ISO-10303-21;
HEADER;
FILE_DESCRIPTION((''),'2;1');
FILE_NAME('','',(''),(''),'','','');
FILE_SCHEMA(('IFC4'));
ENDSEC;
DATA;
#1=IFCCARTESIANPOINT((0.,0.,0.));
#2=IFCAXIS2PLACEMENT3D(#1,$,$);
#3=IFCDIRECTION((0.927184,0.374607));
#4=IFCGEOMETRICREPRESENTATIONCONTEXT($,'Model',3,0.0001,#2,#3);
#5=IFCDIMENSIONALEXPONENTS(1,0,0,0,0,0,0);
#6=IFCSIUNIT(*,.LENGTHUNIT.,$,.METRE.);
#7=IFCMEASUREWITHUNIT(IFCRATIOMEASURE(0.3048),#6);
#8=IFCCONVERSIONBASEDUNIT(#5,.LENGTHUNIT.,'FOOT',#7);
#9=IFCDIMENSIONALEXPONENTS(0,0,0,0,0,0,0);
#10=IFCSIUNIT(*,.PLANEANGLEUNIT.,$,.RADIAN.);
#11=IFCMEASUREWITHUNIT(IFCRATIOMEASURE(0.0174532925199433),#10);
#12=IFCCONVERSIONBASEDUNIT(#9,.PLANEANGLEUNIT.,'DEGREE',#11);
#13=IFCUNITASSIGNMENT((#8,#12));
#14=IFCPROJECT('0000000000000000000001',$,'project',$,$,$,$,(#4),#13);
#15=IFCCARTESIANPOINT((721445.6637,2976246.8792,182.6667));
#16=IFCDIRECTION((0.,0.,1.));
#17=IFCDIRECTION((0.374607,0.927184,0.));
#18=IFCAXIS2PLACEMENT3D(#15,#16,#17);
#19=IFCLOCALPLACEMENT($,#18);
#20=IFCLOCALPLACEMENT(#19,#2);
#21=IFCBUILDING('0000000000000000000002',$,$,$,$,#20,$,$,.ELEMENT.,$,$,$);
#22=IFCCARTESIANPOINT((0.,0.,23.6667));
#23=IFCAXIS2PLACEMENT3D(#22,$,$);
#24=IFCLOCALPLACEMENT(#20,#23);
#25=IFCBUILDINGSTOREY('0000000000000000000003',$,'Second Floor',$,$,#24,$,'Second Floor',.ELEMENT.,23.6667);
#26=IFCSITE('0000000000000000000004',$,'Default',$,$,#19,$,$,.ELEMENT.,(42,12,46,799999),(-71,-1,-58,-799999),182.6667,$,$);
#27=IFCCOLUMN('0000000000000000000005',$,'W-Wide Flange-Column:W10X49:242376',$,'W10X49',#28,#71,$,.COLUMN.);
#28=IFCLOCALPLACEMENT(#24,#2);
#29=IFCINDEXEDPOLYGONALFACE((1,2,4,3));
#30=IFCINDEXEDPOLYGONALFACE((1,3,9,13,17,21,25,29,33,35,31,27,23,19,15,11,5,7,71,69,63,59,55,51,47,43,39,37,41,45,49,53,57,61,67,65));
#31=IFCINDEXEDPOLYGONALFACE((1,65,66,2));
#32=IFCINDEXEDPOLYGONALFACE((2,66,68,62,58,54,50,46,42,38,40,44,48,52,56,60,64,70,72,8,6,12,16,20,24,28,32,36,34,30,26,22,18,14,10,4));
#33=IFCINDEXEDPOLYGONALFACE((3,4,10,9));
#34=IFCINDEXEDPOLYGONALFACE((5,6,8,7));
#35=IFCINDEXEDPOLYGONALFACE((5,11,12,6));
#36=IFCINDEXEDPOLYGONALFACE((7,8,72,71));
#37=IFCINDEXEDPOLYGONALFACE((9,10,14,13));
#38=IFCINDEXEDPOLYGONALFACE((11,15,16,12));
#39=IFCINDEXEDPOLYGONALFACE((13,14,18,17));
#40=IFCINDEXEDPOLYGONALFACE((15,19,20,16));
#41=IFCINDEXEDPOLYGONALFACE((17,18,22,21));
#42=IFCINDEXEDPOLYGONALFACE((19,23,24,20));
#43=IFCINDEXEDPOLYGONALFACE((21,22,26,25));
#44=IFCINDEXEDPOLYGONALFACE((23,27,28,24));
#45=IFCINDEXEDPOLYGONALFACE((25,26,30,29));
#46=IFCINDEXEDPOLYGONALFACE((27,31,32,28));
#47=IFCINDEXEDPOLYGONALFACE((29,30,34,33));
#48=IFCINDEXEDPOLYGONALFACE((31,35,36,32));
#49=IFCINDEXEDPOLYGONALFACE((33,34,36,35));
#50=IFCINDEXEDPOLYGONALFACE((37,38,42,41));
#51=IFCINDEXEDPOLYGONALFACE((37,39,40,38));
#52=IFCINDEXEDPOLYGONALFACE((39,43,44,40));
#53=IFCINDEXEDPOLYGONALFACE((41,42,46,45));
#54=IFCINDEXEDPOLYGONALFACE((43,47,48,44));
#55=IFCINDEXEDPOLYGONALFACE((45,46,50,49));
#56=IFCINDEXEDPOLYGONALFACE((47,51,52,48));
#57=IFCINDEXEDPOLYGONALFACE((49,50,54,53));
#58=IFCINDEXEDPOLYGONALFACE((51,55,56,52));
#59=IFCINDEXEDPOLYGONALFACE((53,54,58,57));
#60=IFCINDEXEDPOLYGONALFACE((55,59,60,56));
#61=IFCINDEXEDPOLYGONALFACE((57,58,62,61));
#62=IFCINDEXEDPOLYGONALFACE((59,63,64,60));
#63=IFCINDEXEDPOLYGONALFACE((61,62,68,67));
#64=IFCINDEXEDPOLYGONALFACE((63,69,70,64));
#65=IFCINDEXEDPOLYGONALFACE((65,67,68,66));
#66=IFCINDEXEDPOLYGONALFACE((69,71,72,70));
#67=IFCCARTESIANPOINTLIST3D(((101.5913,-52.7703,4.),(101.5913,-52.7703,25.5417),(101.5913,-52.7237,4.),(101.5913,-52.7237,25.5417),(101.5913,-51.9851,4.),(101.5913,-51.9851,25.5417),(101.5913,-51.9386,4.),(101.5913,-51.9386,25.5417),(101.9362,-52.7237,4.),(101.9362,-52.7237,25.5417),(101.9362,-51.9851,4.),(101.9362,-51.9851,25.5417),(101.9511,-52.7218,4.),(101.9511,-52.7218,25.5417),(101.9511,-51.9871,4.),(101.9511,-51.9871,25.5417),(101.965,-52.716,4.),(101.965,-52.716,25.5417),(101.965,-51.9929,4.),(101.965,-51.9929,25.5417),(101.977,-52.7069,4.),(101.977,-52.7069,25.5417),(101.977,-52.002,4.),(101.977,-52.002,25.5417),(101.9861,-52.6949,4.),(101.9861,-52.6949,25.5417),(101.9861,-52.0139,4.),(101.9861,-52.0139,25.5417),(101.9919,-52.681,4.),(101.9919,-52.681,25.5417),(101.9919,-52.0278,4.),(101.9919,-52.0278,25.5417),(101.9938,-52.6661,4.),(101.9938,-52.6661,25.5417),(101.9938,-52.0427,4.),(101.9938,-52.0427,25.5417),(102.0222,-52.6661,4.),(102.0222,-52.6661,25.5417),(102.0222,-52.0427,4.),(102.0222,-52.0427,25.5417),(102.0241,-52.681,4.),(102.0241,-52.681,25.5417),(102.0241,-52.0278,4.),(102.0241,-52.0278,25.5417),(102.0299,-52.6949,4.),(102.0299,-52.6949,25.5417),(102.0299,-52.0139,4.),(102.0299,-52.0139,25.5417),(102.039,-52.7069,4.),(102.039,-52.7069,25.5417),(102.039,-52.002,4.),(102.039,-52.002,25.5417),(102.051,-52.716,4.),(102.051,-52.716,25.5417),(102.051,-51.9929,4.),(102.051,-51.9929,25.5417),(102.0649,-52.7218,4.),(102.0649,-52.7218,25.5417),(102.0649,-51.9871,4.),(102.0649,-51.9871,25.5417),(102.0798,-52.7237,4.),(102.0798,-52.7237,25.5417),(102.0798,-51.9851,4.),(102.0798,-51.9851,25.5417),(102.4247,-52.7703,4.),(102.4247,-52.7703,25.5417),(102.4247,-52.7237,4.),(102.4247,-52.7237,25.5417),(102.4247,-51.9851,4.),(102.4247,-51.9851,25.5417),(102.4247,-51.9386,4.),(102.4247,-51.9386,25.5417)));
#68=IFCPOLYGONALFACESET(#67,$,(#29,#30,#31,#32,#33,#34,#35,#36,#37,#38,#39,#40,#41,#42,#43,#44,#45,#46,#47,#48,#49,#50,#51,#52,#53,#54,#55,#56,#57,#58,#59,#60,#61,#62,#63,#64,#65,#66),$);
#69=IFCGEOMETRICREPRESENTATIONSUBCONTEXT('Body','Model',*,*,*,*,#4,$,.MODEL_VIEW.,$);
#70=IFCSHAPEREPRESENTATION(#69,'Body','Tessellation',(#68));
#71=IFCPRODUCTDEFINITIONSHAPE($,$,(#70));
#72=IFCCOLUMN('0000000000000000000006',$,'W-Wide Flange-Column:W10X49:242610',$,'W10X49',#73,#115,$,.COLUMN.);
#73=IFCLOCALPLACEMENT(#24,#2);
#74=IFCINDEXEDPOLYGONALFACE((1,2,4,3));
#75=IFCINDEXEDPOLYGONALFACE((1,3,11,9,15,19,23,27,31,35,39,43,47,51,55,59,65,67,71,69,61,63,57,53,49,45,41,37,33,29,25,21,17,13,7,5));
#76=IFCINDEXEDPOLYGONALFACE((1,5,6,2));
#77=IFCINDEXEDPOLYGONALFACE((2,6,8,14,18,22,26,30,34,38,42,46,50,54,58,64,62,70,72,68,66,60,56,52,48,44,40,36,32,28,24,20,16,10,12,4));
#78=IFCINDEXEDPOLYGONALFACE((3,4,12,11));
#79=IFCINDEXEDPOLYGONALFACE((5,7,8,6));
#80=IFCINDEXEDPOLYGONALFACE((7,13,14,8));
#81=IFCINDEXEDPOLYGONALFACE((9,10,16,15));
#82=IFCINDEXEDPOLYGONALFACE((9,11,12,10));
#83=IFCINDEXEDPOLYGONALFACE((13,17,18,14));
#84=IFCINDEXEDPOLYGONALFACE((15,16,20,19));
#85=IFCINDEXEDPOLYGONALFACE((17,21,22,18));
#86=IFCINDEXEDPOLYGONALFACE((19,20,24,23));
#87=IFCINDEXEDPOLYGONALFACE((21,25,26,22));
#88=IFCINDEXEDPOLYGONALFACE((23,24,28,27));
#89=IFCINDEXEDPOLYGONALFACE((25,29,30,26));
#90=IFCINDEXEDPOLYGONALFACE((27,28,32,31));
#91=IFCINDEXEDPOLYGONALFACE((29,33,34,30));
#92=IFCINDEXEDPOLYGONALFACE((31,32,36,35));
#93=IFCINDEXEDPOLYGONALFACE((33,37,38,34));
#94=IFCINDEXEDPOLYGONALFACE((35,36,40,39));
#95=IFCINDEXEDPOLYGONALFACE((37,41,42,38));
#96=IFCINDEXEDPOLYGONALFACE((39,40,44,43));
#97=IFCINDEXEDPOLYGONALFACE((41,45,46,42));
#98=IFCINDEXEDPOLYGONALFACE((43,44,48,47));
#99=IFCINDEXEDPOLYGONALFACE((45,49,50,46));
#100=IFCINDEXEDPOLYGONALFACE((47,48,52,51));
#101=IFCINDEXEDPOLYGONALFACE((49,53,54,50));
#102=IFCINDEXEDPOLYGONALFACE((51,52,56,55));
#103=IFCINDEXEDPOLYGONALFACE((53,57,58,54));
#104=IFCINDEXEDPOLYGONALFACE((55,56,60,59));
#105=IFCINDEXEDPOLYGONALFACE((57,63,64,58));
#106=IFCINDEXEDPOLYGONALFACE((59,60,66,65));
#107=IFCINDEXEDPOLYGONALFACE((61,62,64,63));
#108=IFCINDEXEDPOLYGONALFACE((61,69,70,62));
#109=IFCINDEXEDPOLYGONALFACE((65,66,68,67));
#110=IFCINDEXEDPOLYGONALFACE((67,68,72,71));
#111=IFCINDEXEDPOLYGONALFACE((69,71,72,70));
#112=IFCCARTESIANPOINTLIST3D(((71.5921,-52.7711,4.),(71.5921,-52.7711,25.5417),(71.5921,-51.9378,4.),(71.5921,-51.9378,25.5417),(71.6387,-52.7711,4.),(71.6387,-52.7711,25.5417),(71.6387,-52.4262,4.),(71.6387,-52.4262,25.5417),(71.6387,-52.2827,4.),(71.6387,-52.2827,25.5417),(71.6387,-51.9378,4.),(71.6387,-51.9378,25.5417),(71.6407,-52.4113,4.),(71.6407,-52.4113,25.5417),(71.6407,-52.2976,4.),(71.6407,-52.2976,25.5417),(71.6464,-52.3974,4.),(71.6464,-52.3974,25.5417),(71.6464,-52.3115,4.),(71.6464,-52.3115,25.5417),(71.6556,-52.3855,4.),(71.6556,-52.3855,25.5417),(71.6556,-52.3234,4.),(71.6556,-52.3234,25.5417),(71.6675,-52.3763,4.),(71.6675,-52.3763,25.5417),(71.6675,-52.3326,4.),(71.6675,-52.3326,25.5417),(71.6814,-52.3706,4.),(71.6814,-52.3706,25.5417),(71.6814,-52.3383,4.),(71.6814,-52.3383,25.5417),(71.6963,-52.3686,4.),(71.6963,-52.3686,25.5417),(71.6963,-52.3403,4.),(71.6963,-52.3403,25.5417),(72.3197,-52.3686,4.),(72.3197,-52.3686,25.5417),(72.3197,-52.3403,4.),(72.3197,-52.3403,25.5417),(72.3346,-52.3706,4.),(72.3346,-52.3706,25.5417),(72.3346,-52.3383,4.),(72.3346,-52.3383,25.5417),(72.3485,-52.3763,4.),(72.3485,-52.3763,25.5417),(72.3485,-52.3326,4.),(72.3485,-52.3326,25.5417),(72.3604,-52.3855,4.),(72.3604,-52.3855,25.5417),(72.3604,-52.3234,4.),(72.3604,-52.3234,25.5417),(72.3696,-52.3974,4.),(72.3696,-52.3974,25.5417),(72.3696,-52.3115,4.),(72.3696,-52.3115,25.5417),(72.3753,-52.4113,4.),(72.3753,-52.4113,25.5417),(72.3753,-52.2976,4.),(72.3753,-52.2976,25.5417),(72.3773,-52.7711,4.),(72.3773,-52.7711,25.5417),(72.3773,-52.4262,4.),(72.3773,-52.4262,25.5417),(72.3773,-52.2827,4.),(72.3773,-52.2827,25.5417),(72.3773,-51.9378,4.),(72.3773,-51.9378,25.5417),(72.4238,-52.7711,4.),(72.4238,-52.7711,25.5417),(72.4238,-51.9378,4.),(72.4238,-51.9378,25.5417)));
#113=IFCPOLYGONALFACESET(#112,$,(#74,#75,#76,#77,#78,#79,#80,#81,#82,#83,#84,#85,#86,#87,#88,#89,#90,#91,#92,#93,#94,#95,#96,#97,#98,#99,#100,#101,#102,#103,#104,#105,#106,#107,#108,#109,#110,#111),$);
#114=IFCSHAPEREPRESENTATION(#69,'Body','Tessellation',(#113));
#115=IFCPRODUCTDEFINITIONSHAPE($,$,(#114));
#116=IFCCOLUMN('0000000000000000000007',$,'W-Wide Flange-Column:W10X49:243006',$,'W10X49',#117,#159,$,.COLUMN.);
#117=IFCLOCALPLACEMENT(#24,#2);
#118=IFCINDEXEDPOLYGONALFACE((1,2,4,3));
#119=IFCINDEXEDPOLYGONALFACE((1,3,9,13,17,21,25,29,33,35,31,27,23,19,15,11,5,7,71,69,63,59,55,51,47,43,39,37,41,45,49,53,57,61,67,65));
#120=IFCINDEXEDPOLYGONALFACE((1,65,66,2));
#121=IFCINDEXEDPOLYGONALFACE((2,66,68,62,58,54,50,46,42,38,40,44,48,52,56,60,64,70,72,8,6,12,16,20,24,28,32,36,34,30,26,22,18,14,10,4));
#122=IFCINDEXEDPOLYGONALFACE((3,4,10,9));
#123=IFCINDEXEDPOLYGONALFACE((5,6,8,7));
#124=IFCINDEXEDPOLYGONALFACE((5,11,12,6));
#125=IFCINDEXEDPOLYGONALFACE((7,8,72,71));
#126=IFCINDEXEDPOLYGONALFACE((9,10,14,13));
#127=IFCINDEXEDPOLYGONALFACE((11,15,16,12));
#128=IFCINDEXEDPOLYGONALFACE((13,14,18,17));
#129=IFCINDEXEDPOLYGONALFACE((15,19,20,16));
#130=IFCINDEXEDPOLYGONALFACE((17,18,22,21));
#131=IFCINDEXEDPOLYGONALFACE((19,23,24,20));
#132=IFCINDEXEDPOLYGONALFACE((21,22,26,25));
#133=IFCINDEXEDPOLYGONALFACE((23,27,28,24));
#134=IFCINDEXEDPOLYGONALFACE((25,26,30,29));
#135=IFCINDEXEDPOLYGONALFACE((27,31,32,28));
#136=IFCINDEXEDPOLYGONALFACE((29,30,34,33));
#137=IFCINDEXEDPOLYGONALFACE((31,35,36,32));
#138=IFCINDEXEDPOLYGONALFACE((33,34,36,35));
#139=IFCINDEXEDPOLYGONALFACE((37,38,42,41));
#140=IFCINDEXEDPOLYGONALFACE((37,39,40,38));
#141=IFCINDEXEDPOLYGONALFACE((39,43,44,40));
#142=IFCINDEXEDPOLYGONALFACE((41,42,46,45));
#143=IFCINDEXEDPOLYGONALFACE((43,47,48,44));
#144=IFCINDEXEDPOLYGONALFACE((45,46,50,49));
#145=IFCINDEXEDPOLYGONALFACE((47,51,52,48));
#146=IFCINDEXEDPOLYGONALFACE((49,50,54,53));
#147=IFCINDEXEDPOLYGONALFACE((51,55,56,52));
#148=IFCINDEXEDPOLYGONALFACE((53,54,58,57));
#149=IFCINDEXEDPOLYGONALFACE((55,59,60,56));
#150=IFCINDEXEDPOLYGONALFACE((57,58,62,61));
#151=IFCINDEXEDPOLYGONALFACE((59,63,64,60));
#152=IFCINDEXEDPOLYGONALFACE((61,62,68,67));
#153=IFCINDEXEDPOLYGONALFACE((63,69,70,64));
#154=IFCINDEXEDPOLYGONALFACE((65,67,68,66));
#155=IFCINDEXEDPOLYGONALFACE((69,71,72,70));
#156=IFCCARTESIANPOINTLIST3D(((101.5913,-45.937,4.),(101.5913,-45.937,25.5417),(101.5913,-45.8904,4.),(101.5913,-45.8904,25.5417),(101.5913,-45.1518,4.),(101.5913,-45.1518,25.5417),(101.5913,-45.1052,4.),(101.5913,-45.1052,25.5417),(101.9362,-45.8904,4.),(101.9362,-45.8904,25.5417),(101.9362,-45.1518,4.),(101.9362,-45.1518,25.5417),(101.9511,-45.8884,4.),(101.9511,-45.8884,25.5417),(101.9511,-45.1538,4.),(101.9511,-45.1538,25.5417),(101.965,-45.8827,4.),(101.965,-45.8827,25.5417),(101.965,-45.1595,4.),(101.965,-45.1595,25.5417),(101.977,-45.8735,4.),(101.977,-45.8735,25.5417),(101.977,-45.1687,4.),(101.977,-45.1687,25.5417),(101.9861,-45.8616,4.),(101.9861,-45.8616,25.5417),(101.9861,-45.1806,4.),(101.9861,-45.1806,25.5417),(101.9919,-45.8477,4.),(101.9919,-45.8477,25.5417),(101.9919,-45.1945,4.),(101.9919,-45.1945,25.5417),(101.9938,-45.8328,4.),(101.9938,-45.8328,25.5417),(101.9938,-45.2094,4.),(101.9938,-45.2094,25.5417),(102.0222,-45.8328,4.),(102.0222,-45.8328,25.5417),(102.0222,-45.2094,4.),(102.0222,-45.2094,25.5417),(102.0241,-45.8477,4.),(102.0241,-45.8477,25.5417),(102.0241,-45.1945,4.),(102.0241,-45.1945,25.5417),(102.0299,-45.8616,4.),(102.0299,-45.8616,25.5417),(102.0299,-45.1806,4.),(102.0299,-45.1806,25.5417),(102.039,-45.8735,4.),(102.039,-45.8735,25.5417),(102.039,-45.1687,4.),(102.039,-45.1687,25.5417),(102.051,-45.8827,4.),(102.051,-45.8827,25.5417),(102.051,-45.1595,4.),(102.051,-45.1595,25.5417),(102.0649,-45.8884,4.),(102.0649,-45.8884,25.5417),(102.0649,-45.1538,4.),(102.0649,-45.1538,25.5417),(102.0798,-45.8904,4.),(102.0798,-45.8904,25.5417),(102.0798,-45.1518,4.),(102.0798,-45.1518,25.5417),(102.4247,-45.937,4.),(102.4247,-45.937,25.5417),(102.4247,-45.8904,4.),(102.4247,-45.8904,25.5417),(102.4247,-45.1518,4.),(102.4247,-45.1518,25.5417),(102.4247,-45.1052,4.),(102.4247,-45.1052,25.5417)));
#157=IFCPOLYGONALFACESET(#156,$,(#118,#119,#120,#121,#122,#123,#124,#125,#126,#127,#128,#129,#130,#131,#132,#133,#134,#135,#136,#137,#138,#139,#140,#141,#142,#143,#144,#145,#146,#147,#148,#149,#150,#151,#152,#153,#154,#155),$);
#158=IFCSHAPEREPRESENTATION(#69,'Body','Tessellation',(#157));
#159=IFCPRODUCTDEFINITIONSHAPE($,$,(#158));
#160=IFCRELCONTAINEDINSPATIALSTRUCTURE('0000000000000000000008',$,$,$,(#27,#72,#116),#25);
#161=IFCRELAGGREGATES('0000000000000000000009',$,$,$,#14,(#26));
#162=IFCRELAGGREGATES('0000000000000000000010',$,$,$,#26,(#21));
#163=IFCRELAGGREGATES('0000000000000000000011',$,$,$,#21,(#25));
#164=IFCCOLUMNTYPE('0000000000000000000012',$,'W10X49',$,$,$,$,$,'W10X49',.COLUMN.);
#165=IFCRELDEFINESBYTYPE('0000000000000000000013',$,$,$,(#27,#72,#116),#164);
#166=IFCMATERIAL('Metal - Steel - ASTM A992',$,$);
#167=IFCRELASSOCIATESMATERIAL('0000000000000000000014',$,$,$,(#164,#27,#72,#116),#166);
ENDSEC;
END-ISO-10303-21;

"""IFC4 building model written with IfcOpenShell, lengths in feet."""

from ifc_helpers import new_model, entity, si_unit, converted_unit, direction, frame, frame_2d, origin, place, context, subcontext, project, spatial, i_section, extrude, source, transform, mapped, material, type_object, type_shapes, element, save


model = new_model("IFC4")

# Units and contexts
model_context = context("Model", 3, precision=0.0001, world=origin(), true_north=direction((0.927184, 0.374607)))
body_context = subcontext(model_context, "Body", "Model", "MODEL_VIEW")
ifc_project = project(units=[converted_unit("LENGTHUNIT", "FOOT", entity("IfcRatioMeasure", 0.3048), si_unit("LENGTHUNIT", "METRE"), dimensions=[1, 0, 0, 0, 0, 0, 0]), converted_unit("PLANEANGLEUNIT", "DEGREE", entity("IfcRatioMeasure", 0.0174532925199433), si_unit("PLANEANGLEUNIT", "RADIAN"), dimensions=[0, 0, 0, 0, 0, 0, 0])], contexts=[model_context])

# Site, building, storey
site_placement = place(None, frame((721445.6637, 2976246.8792, 182.6667), z_axis=(0.0, 0.0, 1.0), x_axis=(0.374607, 0.927184, 0.0)))
site = spatial("IfcSite", under=ifc_project, at=site_placement, Name="Default", CompositionType="ELEMENT", RefLatitude=(42, 12, 46, 799999), RefLongitude=(-71, -1, -58, -799999), RefElevation=182.6667)
building_placement = place(site_placement, origin())
building = spatial("IfcBuilding", under=site, at=building_placement, CompositionType="ELEMENT")
storey_placement = place(building_placement, frame((0.0, 0.0, 23.6667)))
storey = spatial("IfcBuildingStorey", under=building, at=storey_placement, Name="Second Floor", LongName="Second Floor", CompositionType="ELEMENT", Elevation=23.6667)

# Columns
ifc_material_1 = material(Name="Metal - Steel - ASTM A992")
column_type = type_object("IfcColumnType", Name="W10X49", ElementType="W10X49", PredefinedType="COLUMN", material=ifc_material_1)
shared_shape_1 = source(origin(), body_context, "Body", "SweptSolid", [
    extrude(i_section(OverallWidth=0.8333, OverallDepth=0.8317, WebThickness=0.0283, FlangeThickness=0.0465, FilletRadius=0.0576, at=frame_2d((0.0, 0.0), x_axis=(0.0, 1.0))), frame((0.0, 0.0, 27.6667), z_axis=(0.0, 0.0, 1.0), x_axis=(0.0, -1.0, 0.0)), (0.0, 0.0, 1.0), 21.5417),
])
type_shapes(column_type, [shared_shape_1])
for number, where, z_axis, x_axis, name in (
    (1, (102.008, -52.3544, -23.6667), (0.0, 0.0, 1.0), (-1.0, 0.0, 0.0), "W-Wide Flange-Column:W10X49:242376"),
    (2, (72.008, -52.3544, -23.6667), (0.0, 0.0, 1.0), (0.0, 1.0, 0.0), "W-Wide Flange-Column:W10X49:242610"),
    (3, (102.008, -45.5211, -23.6667), (0.0, 0.0, 1.0), (-1.0, 0.0, 0.0), "W-Wide Flange-Column:W10X49:243006"),
):
    element("IfcColumn", number, at=place(storey_placement, frame(where, z_axis=z_axis, x_axis=x_axis)), inside=storey, type_object=column_type, material=ifc_material_1, Name=name, ObjectType="W10X49", PredefinedType="COLUMN", context=body_context, shape_type="MappedRepresentation", body=[
        mapped(shared_shape_1, transform((0.0, 0.0, 0.0), scale=1.0)),
    ])

save(model, "model.ifc")
